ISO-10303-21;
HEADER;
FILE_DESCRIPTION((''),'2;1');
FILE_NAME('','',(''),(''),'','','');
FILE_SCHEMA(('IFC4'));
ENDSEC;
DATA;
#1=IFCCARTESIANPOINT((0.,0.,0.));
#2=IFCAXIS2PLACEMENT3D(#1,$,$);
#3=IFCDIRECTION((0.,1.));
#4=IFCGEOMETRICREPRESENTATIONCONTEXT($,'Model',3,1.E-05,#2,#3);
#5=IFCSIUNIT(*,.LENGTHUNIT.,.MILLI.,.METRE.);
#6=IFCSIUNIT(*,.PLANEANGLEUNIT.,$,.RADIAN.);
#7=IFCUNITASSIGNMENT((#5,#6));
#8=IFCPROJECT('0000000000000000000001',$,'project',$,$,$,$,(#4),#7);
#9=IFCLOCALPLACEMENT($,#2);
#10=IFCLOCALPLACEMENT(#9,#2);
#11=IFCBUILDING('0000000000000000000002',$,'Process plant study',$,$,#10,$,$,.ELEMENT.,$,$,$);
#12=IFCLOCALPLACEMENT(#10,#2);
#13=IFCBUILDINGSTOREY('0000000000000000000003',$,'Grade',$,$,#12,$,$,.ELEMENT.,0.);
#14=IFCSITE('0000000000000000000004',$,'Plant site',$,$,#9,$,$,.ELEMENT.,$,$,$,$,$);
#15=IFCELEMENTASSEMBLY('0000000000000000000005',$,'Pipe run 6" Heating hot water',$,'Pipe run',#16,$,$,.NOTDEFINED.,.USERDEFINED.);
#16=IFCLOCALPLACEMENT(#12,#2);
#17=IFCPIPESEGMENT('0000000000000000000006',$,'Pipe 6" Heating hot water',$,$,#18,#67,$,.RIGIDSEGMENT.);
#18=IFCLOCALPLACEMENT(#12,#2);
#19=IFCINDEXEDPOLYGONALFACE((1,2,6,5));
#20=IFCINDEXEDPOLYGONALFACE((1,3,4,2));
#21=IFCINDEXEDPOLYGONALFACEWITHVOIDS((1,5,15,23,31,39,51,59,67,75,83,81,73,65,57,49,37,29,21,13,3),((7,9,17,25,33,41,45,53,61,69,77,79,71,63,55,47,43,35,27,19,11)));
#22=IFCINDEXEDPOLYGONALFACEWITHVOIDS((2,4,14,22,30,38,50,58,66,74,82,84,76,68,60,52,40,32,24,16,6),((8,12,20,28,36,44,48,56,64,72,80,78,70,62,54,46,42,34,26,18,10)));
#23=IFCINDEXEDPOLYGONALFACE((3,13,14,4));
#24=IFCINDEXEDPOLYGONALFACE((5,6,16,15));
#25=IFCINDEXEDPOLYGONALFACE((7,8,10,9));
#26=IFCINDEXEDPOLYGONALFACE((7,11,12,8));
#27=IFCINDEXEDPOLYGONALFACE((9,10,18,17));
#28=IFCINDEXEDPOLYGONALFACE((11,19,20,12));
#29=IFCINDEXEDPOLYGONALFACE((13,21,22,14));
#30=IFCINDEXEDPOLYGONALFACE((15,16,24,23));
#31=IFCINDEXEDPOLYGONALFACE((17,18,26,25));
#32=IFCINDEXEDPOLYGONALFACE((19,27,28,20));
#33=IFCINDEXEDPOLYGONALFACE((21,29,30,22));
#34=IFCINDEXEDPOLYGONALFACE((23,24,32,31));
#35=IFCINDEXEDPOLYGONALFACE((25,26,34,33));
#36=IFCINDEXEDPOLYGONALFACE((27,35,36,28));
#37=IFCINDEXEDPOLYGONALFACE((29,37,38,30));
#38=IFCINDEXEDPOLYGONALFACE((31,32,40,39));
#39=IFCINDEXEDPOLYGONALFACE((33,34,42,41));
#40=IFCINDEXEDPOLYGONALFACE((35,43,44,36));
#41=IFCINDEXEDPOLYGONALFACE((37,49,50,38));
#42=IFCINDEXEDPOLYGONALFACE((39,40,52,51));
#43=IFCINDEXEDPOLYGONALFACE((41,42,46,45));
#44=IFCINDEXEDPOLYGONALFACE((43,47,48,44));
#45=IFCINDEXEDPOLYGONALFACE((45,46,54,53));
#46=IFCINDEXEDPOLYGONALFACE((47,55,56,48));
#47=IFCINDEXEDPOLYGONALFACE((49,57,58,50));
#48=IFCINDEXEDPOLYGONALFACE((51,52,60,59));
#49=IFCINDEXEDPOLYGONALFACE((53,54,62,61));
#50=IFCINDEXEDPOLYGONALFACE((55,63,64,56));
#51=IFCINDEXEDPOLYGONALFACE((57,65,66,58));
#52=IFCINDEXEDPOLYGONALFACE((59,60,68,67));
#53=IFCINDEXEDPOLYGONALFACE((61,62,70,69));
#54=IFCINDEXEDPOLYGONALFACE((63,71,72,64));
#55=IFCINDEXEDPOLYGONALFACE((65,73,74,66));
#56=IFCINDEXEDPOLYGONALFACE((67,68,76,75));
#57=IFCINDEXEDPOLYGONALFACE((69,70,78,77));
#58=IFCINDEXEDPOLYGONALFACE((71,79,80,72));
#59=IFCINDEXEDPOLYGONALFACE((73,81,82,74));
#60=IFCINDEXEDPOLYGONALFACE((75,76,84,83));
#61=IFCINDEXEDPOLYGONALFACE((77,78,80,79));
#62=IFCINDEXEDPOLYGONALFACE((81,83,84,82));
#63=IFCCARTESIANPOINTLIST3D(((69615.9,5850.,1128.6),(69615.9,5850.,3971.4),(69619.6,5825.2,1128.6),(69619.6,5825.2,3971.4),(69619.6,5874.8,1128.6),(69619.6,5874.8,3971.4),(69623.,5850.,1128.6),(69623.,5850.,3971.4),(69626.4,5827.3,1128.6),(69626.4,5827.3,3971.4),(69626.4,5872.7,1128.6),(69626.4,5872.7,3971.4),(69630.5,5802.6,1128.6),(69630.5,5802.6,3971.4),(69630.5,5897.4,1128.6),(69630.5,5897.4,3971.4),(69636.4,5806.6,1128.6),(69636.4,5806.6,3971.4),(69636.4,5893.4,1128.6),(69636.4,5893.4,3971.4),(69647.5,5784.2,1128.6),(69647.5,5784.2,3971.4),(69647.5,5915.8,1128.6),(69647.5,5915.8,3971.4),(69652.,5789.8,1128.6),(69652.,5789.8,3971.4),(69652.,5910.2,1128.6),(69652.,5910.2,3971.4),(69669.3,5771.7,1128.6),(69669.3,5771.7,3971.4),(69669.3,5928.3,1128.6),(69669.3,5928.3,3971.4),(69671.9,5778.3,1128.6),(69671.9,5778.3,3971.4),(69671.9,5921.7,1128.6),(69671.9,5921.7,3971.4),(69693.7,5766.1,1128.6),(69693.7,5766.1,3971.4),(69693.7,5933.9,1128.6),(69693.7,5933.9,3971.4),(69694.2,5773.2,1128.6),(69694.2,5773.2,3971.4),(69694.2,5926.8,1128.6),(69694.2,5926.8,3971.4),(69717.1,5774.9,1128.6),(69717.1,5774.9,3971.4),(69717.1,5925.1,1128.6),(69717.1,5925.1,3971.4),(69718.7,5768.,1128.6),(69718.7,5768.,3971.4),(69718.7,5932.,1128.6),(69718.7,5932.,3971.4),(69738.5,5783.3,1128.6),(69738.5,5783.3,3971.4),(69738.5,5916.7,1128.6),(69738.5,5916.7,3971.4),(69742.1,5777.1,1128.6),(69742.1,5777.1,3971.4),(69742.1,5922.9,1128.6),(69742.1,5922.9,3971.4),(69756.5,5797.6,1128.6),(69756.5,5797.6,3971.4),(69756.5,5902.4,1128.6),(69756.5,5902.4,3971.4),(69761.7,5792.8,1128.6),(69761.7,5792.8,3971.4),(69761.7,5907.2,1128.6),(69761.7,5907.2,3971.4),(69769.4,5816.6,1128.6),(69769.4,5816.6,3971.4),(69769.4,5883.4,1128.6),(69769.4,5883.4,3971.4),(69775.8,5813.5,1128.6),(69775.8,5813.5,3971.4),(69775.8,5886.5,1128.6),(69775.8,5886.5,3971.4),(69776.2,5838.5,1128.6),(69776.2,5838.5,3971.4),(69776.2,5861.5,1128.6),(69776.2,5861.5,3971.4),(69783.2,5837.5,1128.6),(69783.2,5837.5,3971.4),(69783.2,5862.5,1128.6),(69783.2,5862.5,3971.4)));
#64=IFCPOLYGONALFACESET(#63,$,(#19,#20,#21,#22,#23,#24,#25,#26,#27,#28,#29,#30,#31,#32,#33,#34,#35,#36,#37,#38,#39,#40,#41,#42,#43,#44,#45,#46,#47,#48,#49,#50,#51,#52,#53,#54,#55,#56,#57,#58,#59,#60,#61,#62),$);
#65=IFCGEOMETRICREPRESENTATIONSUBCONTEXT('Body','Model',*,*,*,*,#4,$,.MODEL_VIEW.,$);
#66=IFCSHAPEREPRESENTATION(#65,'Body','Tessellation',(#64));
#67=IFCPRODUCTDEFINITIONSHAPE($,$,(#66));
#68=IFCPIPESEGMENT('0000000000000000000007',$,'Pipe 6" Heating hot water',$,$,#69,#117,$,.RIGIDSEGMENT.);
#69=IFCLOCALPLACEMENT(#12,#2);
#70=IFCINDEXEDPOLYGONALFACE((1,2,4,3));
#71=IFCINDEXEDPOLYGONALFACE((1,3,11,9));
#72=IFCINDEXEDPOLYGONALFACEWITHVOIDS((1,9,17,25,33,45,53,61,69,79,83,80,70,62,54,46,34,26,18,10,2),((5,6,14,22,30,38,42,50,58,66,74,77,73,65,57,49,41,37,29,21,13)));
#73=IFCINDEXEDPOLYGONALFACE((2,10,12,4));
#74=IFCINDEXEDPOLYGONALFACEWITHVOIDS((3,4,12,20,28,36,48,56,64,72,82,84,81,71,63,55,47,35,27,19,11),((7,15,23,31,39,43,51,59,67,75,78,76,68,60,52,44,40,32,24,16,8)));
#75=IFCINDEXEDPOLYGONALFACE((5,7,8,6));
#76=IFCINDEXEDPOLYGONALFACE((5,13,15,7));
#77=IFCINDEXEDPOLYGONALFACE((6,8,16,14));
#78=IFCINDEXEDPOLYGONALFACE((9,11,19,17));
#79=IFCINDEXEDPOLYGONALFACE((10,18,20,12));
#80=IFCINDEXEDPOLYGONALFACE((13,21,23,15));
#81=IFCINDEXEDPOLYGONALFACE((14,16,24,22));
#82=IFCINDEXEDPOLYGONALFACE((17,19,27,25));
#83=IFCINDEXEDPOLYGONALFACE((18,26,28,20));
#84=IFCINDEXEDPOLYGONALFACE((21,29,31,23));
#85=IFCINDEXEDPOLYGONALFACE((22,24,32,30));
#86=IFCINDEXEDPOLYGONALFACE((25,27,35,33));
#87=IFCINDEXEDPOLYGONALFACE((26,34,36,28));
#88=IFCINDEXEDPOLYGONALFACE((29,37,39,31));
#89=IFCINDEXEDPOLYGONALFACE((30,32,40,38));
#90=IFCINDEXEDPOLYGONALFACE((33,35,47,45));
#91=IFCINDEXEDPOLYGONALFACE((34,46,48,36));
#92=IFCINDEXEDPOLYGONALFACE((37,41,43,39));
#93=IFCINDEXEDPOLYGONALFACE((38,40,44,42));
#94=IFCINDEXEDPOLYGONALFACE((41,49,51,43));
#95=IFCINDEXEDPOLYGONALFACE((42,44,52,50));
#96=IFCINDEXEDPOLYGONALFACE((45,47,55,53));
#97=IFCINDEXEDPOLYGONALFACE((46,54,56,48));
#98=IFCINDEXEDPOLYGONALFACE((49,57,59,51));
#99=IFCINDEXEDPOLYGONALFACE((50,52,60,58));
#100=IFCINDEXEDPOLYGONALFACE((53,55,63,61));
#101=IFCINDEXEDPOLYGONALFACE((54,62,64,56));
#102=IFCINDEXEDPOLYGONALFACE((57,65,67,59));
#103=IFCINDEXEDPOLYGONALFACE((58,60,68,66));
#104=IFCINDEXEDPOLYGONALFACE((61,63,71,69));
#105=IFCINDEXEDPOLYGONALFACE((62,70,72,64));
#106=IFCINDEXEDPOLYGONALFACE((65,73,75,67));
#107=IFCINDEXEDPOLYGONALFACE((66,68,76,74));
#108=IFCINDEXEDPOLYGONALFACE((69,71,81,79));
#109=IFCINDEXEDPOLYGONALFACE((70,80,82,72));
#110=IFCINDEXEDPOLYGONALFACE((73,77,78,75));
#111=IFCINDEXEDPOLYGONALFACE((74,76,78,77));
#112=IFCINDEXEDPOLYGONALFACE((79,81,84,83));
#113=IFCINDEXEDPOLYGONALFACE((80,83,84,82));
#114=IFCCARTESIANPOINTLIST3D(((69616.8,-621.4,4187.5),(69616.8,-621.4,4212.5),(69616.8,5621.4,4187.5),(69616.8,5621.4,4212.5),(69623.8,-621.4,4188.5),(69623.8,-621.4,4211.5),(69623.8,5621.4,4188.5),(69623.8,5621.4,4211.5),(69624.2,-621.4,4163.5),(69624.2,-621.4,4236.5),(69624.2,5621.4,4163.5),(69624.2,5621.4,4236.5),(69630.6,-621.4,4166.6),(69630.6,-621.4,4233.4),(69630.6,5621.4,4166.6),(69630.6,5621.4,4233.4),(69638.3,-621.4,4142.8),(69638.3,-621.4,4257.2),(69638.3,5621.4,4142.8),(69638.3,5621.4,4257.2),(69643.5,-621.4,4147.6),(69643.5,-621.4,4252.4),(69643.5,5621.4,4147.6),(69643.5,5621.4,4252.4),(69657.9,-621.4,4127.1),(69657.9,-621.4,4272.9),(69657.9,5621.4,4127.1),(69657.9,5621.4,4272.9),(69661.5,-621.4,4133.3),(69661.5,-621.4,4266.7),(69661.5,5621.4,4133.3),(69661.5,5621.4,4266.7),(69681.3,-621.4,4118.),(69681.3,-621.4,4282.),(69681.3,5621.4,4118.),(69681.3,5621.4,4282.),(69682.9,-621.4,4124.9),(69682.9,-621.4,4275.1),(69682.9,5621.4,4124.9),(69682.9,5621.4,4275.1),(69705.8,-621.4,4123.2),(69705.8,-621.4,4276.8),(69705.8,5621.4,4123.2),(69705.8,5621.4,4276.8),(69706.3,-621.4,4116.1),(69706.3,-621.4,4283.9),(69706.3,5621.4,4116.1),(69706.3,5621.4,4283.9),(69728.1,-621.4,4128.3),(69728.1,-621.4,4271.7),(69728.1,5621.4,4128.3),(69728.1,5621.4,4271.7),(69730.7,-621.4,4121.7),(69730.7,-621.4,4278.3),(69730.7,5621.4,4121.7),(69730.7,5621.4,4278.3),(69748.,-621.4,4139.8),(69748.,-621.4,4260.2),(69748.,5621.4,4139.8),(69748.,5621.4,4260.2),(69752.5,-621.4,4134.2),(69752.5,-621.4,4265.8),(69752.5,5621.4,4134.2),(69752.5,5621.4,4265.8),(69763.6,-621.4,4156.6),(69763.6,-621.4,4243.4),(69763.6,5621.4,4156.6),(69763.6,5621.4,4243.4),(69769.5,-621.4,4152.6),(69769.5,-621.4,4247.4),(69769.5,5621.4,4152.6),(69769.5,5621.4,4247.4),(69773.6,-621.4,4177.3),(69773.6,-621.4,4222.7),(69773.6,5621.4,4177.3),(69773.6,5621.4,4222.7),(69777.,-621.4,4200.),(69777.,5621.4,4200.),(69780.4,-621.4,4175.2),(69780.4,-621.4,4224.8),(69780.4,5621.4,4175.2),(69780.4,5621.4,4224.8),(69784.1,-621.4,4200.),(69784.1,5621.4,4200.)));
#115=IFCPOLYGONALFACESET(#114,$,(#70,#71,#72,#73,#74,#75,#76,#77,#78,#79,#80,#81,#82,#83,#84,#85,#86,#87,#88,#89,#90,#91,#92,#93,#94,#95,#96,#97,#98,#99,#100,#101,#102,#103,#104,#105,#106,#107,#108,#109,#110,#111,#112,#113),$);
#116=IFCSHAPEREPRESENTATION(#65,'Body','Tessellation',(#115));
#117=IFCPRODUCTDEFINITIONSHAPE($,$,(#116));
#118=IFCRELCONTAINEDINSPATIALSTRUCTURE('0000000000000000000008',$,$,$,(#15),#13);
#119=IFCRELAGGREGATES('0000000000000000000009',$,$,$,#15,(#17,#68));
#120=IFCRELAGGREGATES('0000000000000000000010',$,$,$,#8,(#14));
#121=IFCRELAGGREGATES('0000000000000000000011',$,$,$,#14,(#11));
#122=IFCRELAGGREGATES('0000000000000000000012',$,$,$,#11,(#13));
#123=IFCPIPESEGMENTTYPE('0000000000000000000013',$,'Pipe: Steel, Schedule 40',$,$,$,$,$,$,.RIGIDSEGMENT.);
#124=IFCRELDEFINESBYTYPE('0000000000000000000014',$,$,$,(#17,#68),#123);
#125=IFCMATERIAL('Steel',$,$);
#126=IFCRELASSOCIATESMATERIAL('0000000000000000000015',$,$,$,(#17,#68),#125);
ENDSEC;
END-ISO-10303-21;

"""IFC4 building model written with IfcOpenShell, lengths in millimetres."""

from ifc_helpers import new_model, si_unit, direction, frame, origin, origin_with_axes, origin_2d, place, context, subcontext, project, spatial, hollow_circle, extrude, material, type_object, element, aggregate, save


model = new_model("IFC4")

# Units and contexts
model_context = context("Model", 3, precision=1e-05, world=origin(), true_north=direction((0.0, 1.0)))
body_context = subcontext(model_context, "Body", "Model", "MODEL_VIEW")
ifc_project = project(units=[si_unit("LENGTHUNIT", "METRE", prefix="MILLI"), si_unit("PLANEANGLEUNIT", "RADIAN")], contexts=[model_context])

# Site, building, storey
site_placement = place(None, origin())
site = spatial("IfcSite", under=ifc_project, at=site_placement, Name="Plant site", CompositionType="ELEMENT")
building_placement = place(site_placement, origin())
building = spatial("IfcBuilding", under=site, at=building_placement, Name="Process plant study", CompositionType="ELEMENT")
storey_placement = place(building_placement, origin())
storey = spatial("IfcBuildingStorey", under=building, at=storey_placement, Name="Grade", CompositionType="ELEMENT", Elevation=0.0)

# Element assembly, pipe segments
ifc_material = material(Name="Steel")
pipe_segment_type = type_object("IfcPipeSegmentType", Name="Pipe: Steel, Schedule 40", PredefinedType="RIGIDSEGMENT")
assembly_1_placement = place(storey_placement, origin_with_axes())
assembly_1 = element("IfcElementAssembly", 1, at=assembly_1_placement, inside=storey, Name="Pipe run 6\" Heating hot water", ObjectType="Pipe run", AssemblyPlace="NOTDEFINED", PredefinedType="USERDEFINED")
pipe_segment_1_placement = place(storey_placement, origin_with_axes())
pipe_segment_1 = element("IfcPipeSegment", 2, at=pipe_segment_1_placement, type_object=pipe_segment_type, material=ifc_material, Name="Pipe 6\" Heating hot water", PredefinedType="RIGIDSEGMENT", context=body_context, shape_type="SweptSolid", body=[
    extrude(hollow_circle(Radius=84.1, WallThickness=7.1, at=origin_2d()), frame((69700.0, 5850.0, 1128.6), z_axis=(0.0, 0.0, 1.0), x_axis=(-1.0, 0.0, 0.0)), (0.0, 0.0, 1.0), 2842.8),
])
pipe_segment_2_placement = place(storey_placement, origin_with_axes())
pipe_segment_2 = element("IfcPipeSegment", 3, at=pipe_segment_2_placement, type_object=pipe_segment_type, material=ifc_material, Name="Pipe 6\" Heating hot water", PredefinedType="RIGIDSEGMENT", context=body_context, shape_type="SweptSolid", body=[
    extrude(hollow_circle(Radius=84.1, WallThickness=7.1, at=origin_2d()), frame((69700.0, 5621.4, 4200.0), z_axis=(0.0, -1.0, 0.0), x_axis=(1.0, 0.0, 0.0)), (0.0, 0.0, 1.0), 6242.8),
])

aggregate(assembly_1, [pipe_segment_1, pipe_segment_2])

save(model, "model.ifc")
